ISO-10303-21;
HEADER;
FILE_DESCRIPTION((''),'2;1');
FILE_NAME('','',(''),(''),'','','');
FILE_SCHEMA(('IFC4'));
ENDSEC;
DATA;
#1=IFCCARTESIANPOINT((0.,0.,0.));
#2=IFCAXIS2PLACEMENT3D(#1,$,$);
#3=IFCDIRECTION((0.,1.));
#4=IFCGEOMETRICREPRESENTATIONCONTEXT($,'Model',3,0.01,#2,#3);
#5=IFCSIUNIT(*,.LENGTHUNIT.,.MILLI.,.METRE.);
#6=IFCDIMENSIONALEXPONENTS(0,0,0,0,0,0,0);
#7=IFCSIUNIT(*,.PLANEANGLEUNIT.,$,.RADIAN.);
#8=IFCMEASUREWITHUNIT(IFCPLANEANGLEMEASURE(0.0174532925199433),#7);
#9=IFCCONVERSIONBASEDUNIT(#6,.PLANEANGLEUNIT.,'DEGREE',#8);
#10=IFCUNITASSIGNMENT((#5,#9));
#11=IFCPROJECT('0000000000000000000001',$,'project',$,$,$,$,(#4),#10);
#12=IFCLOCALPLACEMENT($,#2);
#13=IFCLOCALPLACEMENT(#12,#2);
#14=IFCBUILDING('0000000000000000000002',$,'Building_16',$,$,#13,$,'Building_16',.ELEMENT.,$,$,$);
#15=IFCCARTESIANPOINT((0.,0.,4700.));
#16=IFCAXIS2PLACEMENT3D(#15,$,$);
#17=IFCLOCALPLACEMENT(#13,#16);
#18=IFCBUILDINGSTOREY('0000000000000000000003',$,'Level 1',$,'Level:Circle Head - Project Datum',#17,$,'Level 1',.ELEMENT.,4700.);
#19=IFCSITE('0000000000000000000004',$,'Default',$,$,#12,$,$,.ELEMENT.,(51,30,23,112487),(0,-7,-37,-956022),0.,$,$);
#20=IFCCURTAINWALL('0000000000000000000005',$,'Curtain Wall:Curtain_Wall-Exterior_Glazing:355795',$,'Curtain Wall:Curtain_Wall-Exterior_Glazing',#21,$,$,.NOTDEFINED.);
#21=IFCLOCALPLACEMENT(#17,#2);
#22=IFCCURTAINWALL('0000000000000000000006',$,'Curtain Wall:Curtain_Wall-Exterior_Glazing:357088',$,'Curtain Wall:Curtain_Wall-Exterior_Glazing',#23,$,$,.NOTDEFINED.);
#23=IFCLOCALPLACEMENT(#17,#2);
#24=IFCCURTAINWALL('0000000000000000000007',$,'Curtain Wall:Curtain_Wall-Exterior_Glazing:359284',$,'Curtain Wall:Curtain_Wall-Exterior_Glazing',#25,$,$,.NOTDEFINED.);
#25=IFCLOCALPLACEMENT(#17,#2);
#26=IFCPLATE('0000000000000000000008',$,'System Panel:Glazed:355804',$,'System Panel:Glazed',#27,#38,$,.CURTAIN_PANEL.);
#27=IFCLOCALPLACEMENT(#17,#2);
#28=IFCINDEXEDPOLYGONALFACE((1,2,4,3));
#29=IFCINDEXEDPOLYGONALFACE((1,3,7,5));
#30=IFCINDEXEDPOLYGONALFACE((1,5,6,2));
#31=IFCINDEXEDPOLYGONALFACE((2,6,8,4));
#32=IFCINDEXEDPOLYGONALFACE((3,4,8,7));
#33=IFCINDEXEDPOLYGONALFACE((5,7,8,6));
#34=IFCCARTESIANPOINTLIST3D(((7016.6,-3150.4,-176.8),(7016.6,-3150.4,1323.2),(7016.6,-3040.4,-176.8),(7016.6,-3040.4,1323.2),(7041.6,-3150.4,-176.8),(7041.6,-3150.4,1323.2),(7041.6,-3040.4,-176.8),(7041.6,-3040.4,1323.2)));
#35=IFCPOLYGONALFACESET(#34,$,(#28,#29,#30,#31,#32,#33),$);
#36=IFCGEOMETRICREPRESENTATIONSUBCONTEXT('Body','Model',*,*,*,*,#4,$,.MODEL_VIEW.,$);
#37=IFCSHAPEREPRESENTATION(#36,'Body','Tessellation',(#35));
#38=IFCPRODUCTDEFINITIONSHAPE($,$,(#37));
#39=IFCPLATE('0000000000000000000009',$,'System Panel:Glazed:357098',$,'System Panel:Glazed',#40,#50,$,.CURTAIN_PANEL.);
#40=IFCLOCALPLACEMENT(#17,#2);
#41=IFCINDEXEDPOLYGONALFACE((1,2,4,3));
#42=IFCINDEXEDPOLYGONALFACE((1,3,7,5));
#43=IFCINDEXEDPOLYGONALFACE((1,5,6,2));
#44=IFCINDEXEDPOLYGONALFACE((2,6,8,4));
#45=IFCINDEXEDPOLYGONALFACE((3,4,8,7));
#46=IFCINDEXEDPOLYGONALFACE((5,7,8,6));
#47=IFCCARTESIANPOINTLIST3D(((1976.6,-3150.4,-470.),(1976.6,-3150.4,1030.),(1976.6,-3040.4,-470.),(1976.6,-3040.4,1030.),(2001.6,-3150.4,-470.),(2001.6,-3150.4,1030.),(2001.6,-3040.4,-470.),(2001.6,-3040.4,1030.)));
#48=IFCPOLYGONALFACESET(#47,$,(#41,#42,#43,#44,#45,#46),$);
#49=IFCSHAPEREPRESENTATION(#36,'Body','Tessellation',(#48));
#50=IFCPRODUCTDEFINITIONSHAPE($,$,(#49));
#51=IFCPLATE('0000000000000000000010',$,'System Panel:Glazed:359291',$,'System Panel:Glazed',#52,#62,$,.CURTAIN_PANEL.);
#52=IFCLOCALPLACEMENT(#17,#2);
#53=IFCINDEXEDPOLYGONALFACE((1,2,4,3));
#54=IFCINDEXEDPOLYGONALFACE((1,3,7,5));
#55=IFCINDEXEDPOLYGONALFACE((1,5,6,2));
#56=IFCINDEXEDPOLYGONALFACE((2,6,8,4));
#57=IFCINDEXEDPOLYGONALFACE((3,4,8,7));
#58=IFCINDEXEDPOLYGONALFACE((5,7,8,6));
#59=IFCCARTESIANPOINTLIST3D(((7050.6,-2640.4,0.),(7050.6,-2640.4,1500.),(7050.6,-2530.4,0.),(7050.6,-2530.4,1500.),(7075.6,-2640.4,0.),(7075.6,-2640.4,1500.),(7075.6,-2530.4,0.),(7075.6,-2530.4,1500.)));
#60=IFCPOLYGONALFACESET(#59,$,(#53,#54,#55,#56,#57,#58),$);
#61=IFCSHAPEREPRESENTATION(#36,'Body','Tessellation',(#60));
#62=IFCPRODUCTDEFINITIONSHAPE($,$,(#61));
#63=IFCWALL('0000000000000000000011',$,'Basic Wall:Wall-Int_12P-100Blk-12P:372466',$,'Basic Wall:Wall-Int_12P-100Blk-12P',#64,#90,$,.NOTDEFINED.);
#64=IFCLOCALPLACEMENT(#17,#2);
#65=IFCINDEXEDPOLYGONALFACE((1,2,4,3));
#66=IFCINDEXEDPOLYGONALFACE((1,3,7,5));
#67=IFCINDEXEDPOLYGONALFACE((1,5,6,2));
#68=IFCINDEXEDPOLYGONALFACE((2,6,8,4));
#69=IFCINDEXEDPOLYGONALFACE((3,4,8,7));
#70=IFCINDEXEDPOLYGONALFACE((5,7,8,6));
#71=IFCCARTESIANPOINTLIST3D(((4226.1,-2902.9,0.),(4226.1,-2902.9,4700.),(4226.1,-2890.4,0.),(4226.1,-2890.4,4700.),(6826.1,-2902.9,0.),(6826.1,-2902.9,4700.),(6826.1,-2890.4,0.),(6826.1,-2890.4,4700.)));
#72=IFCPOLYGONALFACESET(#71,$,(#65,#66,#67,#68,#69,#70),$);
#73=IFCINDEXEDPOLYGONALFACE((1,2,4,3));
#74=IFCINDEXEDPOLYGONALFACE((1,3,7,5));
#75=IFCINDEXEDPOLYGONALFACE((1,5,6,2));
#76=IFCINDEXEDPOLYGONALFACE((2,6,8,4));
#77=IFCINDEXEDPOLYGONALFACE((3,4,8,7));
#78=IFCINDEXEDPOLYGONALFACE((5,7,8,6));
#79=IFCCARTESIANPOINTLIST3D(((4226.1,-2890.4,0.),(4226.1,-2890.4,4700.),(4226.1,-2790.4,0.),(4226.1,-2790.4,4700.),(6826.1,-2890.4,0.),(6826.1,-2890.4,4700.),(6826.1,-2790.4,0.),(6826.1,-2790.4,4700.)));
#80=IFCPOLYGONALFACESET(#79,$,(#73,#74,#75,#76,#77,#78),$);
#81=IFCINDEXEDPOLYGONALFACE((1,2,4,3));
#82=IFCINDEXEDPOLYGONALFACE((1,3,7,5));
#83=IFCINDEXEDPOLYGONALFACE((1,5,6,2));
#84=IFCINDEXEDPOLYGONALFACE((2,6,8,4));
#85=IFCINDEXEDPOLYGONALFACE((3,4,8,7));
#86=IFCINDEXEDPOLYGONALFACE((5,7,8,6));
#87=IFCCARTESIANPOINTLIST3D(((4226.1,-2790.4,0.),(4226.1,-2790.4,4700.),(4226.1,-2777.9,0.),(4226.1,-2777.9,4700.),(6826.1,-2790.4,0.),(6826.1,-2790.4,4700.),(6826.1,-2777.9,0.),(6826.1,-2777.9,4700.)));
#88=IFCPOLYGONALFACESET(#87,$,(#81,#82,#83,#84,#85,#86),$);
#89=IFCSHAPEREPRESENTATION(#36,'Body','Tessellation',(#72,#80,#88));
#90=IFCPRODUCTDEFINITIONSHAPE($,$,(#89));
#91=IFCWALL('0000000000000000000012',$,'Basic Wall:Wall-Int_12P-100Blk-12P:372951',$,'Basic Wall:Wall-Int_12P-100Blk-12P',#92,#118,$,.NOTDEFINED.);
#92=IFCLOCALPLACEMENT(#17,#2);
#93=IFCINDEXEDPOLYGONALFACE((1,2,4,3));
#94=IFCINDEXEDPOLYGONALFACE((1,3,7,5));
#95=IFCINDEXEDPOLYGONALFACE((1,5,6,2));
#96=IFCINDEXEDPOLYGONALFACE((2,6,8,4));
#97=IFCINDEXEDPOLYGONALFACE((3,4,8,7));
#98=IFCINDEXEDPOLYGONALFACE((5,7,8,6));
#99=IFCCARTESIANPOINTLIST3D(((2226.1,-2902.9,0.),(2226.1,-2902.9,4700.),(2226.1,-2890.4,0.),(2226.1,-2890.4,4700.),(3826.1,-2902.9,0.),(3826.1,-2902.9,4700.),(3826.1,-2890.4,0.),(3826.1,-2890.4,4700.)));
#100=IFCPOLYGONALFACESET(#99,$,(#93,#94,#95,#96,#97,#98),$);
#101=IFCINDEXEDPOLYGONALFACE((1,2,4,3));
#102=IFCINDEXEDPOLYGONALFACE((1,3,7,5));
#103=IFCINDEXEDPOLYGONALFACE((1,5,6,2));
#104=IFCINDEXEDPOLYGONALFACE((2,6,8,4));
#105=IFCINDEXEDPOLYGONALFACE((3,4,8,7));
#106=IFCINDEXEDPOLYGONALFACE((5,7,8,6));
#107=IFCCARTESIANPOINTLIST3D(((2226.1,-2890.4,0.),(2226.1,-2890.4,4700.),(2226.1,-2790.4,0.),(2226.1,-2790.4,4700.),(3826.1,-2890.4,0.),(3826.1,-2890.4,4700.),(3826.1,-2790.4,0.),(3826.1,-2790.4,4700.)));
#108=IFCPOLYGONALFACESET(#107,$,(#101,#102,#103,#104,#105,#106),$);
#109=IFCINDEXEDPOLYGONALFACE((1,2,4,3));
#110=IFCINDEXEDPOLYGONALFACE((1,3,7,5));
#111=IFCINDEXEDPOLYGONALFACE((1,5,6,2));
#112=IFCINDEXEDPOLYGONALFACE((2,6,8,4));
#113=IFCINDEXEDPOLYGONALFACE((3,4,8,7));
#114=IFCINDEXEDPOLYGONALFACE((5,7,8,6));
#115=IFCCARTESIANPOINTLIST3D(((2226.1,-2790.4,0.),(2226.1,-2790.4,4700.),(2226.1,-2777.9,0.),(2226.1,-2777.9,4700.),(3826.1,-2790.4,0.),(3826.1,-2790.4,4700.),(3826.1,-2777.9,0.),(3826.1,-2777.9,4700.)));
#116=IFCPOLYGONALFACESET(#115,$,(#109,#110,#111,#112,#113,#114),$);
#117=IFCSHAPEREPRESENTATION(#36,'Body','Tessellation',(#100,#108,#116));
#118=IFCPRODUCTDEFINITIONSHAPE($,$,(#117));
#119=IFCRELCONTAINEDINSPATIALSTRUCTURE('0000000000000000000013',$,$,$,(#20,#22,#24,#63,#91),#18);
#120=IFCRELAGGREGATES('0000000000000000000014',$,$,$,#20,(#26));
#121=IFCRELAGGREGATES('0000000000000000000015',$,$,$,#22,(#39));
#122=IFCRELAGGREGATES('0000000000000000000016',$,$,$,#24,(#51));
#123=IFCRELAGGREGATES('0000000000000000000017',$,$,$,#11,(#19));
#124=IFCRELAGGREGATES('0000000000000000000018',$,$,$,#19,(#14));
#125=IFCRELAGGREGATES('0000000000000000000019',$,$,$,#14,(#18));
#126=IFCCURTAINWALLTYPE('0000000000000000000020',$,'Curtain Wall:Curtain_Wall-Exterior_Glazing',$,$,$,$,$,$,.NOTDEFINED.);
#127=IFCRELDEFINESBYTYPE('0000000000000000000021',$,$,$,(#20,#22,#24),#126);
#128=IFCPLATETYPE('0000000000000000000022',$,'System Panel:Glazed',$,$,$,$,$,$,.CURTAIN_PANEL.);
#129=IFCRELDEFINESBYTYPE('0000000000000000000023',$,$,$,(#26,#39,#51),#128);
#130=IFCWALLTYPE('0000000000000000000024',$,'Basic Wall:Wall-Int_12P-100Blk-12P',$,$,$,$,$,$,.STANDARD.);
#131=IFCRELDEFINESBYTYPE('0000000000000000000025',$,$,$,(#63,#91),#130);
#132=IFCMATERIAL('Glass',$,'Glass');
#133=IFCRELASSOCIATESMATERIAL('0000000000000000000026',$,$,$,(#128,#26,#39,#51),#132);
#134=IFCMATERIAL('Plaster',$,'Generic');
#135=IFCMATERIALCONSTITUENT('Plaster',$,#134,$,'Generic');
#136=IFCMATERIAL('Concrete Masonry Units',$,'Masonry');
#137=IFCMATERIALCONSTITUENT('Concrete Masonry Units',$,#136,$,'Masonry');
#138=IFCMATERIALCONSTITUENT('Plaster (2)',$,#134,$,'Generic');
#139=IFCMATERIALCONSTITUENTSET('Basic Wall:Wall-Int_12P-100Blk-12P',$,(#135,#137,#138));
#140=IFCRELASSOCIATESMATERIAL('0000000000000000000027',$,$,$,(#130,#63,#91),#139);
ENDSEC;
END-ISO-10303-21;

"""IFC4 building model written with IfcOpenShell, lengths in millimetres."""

from ifc_helpers import new_model, entity, si_unit, converted_unit, direction, frame, origin, place, context, subcontext, project, spatial, indexed_curve, outline, extrude, source, transform, mapped, material, constituent, constituent_set, type_object, type_shapes, element, aggregate, save


model = new_model("IFC4")

# Units and contexts
model_context = context("Model", 3, precision=0.01, world=origin(), true_north=direction((0.0, 1.0)))
body_context = subcontext(model_context, "Body", "Model", "MODEL_VIEW")
ifc_project = project(units=[si_unit("LENGTHUNIT", "METRE", prefix="MILLI"), converted_unit("PLANEANGLEUNIT", "DEGREE", entity("IfcPlaneAngleMeasure", 0.0174532925199433), si_unit("PLANEANGLEUNIT", "RADIAN"), dimensions=[0, 0, 0, 0, 0, 0, 0])], contexts=[model_context])

# Site, building, storey
site_placement = place(None, origin())
site = spatial("IfcSite", under=ifc_project, at=site_placement, Name="Default", CompositionType="ELEMENT", RefLatitude=(51, 30, 23, 112487), RefLongitude=(0, -7, -37, -956022), RefElevation=0.0)
building_placement = place(site_placement, origin())
building = spatial("IfcBuilding", under=site, at=building_placement, Name="Building_16", LongName="Building_16", CompositionType="ELEMENT")
storey_placement = place(building_placement, frame((0.0, 0.0, 4700.0)))
storey = spatial("IfcBuildingStorey", under=building, at=storey_placement, Name="Level 1", ObjectType="Level:Circle Head - Project Datum", LongName="Level 1", CompositionType="ELEMENT", Elevation=4700.0)

# Shared definitions
ifc_material_1 = material(Name="Plaster", Category="Generic")

# Curtain walls
curtain_wall_type = type_object("IfcCurtainWallType", Name="Curtain Wall:Curtain_Wall-Exterior_Glazing", PredefinedType="NOTDEFINED")
curtain_wall_1_placement = place(storey_placement, frame((0.0, 0.0, -4700.0)))
curtain_wall_1 = element("IfcCurtainWall", 1, at=curtain_wall_1_placement, inside=storey, type_object=curtain_wall_type, Name="Curtain Wall:Curtain_Wall-Exterior_Glazing:355795", ObjectType="Curtain Wall:Curtain_Wall-Exterior_Glazing", PredefinedType="NOTDEFINED")
ifc_material_2 = material(Name="Glass", Category="Glass")
curtain_wall_2_placement = place(storey_placement, frame((0.0, 0.0, -4700.0)))
curtain_wall_2 = element("IfcCurtainWall", 2, at=curtain_wall_2_placement, inside=storey, type_object=curtain_wall_type, Name="Curtain Wall:Curtain_Wall-Exterior_Glazing:357088", ObjectType="Curtain Wall:Curtain_Wall-Exterior_Glazing", PredefinedType="NOTDEFINED")

# Curtain wall
curtain_wall_3_placement = place(storey_placement, frame((0.0, 0.0, -4700.0)))
curtain_wall_3 = element("IfcCurtainWall", 3, at=curtain_wall_3_placement, inside=storey, type_object=curtain_wall_type, Name="Curtain Wall:Curtain_Wall-Exterior_Glazing:359284", ObjectType="Curtain Wall:Curtain_Wall-Exterior_Glazing", PredefinedType="NOTDEFINED")

# Plates
plate_type_1 = type_object("IfcPlateType", Name="System Panel:Glazed", PredefinedType="CURTAIN_PANEL", material=ifc_material_2)
shared_shape_1 = source(origin(), body_context, "Body", "SweptSolid", [
    extrude(outline(indexed_curve([(-12.5, -55.0), (12.5, -55.0), (12.5, 55.0), (-12.5, 55.0), (-12.5, -55.0)], self_intersect=False)), frame((0.0, 37.0, 0.0), z_axis=(0.0, 0.0, 1.0), x_axis=(0.0, 1.0, 0.0)), (0.0, 0.0, 1.0), 1500.0),
])
type_shapes(plate_type_1, [shared_shape_1])
plate_1_placement = place(curtain_wall_1_placement, frame((7066.1, -3095.4, 4523.2), z_axis=(0.0, 0.0, 1.0), x_axis=(0.0, 1.0, 0.0)))
plate_1 = element("IfcPlate", 4, at=plate_1_placement, type_object=plate_type_1, material=ifc_material_2, Name="System Panel:Glazed:355804", ObjectType="System Panel:Glazed", PredefinedType="CURTAIN_PANEL", context=body_context, shape_type="MappedRepresentation", body=[
    mapped(shared_shape_1, transform((0.0, 0.0, 0.0), scale=1.0)),
])
aggregate(curtain_wall_1, [plate_1])
plate_2_placement = place(curtain_wall_2_placement, frame((2026.1, -3095.4, 4230.0), z_axis=(0.0, 0.0, 1.0), x_axis=(0.0, 1.0, 0.0)))
plate_2 = element("IfcPlate", 5, at=plate_2_placement, type_object=plate_type_1, material=ifc_material_2, Name="System Panel:Glazed:357098", ObjectType="System Panel:Glazed", PredefinedType="CURTAIN_PANEL", context=body_context, shape_type="MappedRepresentation", body=[
    mapped(shared_shape_1, transform((0.0, 0.0, 0.0), scale=1.0)),
])
aggregate(curtain_wall_2, [plate_2])
plate_3_placement = place(curtain_wall_3_placement, frame((7026.1, -2585.4, 4700.0), z_axis=(0.0, 0.0, 1.0), x_axis=(0.0, -1.0, 0.0)))
plate_3 = element("IfcPlate", 6, at=plate_3_placement, type_object=plate_type_1, material=ifc_material_2, Name="System Panel:Glazed:359291", ObjectType="System Panel:Glazed", PredefinedType="CURTAIN_PANEL", context=body_context, shape_type="MappedRepresentation", body=[
    mapped(shared_shape_1, transform((0.0, 0.0, 0.0), scale=1.0)),
])
aggregate(curtain_wall_3, [plate_3])

# Wall
ifc_constituent_1 = constituent(ifc_material_1, Name="Plaster", Category="Generic")
ifc_material_3 = material(Name="Concrete Masonry Units", Category="Masonry")
ifc_constituent_2 = constituent(ifc_material_3, Name="Concrete Masonry Units", Category="Masonry")
ifc_constituent_3 = constituent(ifc_material_1, Name="Plaster (2)", Category="Generic")
ifc_constituent_set_1 = constituent_set(constituents=[ifc_constituent_1, ifc_constituent_2, ifc_constituent_3], Name="Basic Wall:Wall-Int_12P-100Blk-12P")
wall_type = type_object("IfcWallType", Name="Basic Wall:Wall-Int_12P-100Blk-12P", PredefinedType="STANDARD", material=ifc_constituent_set_1)
wall_1_placement = place(storey_placement, frame((4226.1, -2840.4, 0.0)))
element("IfcWall", 7, at=wall_1_placement, inside=storey, type_object=wall_type, material=ifc_constituent_set_1, Name="Basic Wall:Wall-Int_12P-100Blk-12P:372466", ObjectType="Basic Wall:Wall-Int_12P-100Blk-12P", PredefinedType="NOTDEFINED", context=body_context, shape_type="SweptSolid", body=[
    extrude(outline(indexed_curve([(-6.3, -1300.0), (6.2, -1300.0), (6.3, 1300.0), (-6.2, 1300.0), (-6.3, -1300.0)], self_intersect=False)), frame((1300.0, -56.3, 0.0), z_axis=(0.0, 0.0, 1.0), x_axis=(0.0, 1.0, 0.0)), (0.0, 0.0, 1.0), 4700.0),
    extrude(outline(indexed_curve([(-1300.0, -50.0), (1300.0, -50.0), (1300.0, 50.0), (-1300.0, 50.0), (-1300.0, -50.0)], self_intersect=False)), frame((1300.0, 0.0, 0.0)), (0.0, 0.0, 1.0), 4700.0),
    extrude(outline(indexed_curve([(-6.3, -1300.0), (6.2, -1300.0), (6.3, 1300.0), (-6.2, 1300.0), (-6.3, -1300.0)], self_intersect=False)), frame((1300.0, 56.3, 0.0), z_axis=(0.0, 0.0, 1.0), x_axis=(0.0, -1.0, 0.0)), (0.0, 0.0, 1.0), 4700.0),
])

# Wall
wall_2_placement = place(storey_placement, frame((2226.1, -2840.4, 0.0)))
element("IfcWall", 8, at=wall_2_placement, inside=storey, type_object=wall_type, material=ifc_constituent_set_1, Name="Basic Wall:Wall-Int_12P-100Blk-12P:372951", ObjectType="Basic Wall:Wall-Int_12P-100Blk-12P", PredefinedType="NOTDEFINED", context=body_context, shape_type="SweptSolid", body=[
    extrude(outline(indexed_curve([(-6.3, -800.0), (6.2, -800.0), (6.3, 800.0), (-6.2, 800.0), (-6.3, -800.0)], self_intersect=False)), frame((800.0, -56.3, 0.0), z_axis=(0.0, 0.0, 1.0), x_axis=(0.0, 1.0, 0.0)), (0.0, 0.0, 1.0), 4700.0),
    extrude(outline(indexed_curve([(-800.0, -50.0), (800.0, -50.0), (800.0, 50.0), (-800.0, 50.0), (-800.0, -50.0)], self_intersect=False)), frame((800.0, 0.0, 0.0)), (0.0, 0.0, 1.0), 4700.0),
    extrude(outline(indexed_curve([(-6.3, -800.0), (6.2, -800.0), (6.3, 800.0), (-6.2, 800.0), (-6.3, -800.0)], self_intersect=False)), frame((800.0, 56.2, 0.0), z_axis=(0.0, 0.0, 1.0), x_axis=(0.0, -1.0, 0.0)), (0.0, 0.0, 1.0), 4700.0),
])

save(model, "model.ifc")
